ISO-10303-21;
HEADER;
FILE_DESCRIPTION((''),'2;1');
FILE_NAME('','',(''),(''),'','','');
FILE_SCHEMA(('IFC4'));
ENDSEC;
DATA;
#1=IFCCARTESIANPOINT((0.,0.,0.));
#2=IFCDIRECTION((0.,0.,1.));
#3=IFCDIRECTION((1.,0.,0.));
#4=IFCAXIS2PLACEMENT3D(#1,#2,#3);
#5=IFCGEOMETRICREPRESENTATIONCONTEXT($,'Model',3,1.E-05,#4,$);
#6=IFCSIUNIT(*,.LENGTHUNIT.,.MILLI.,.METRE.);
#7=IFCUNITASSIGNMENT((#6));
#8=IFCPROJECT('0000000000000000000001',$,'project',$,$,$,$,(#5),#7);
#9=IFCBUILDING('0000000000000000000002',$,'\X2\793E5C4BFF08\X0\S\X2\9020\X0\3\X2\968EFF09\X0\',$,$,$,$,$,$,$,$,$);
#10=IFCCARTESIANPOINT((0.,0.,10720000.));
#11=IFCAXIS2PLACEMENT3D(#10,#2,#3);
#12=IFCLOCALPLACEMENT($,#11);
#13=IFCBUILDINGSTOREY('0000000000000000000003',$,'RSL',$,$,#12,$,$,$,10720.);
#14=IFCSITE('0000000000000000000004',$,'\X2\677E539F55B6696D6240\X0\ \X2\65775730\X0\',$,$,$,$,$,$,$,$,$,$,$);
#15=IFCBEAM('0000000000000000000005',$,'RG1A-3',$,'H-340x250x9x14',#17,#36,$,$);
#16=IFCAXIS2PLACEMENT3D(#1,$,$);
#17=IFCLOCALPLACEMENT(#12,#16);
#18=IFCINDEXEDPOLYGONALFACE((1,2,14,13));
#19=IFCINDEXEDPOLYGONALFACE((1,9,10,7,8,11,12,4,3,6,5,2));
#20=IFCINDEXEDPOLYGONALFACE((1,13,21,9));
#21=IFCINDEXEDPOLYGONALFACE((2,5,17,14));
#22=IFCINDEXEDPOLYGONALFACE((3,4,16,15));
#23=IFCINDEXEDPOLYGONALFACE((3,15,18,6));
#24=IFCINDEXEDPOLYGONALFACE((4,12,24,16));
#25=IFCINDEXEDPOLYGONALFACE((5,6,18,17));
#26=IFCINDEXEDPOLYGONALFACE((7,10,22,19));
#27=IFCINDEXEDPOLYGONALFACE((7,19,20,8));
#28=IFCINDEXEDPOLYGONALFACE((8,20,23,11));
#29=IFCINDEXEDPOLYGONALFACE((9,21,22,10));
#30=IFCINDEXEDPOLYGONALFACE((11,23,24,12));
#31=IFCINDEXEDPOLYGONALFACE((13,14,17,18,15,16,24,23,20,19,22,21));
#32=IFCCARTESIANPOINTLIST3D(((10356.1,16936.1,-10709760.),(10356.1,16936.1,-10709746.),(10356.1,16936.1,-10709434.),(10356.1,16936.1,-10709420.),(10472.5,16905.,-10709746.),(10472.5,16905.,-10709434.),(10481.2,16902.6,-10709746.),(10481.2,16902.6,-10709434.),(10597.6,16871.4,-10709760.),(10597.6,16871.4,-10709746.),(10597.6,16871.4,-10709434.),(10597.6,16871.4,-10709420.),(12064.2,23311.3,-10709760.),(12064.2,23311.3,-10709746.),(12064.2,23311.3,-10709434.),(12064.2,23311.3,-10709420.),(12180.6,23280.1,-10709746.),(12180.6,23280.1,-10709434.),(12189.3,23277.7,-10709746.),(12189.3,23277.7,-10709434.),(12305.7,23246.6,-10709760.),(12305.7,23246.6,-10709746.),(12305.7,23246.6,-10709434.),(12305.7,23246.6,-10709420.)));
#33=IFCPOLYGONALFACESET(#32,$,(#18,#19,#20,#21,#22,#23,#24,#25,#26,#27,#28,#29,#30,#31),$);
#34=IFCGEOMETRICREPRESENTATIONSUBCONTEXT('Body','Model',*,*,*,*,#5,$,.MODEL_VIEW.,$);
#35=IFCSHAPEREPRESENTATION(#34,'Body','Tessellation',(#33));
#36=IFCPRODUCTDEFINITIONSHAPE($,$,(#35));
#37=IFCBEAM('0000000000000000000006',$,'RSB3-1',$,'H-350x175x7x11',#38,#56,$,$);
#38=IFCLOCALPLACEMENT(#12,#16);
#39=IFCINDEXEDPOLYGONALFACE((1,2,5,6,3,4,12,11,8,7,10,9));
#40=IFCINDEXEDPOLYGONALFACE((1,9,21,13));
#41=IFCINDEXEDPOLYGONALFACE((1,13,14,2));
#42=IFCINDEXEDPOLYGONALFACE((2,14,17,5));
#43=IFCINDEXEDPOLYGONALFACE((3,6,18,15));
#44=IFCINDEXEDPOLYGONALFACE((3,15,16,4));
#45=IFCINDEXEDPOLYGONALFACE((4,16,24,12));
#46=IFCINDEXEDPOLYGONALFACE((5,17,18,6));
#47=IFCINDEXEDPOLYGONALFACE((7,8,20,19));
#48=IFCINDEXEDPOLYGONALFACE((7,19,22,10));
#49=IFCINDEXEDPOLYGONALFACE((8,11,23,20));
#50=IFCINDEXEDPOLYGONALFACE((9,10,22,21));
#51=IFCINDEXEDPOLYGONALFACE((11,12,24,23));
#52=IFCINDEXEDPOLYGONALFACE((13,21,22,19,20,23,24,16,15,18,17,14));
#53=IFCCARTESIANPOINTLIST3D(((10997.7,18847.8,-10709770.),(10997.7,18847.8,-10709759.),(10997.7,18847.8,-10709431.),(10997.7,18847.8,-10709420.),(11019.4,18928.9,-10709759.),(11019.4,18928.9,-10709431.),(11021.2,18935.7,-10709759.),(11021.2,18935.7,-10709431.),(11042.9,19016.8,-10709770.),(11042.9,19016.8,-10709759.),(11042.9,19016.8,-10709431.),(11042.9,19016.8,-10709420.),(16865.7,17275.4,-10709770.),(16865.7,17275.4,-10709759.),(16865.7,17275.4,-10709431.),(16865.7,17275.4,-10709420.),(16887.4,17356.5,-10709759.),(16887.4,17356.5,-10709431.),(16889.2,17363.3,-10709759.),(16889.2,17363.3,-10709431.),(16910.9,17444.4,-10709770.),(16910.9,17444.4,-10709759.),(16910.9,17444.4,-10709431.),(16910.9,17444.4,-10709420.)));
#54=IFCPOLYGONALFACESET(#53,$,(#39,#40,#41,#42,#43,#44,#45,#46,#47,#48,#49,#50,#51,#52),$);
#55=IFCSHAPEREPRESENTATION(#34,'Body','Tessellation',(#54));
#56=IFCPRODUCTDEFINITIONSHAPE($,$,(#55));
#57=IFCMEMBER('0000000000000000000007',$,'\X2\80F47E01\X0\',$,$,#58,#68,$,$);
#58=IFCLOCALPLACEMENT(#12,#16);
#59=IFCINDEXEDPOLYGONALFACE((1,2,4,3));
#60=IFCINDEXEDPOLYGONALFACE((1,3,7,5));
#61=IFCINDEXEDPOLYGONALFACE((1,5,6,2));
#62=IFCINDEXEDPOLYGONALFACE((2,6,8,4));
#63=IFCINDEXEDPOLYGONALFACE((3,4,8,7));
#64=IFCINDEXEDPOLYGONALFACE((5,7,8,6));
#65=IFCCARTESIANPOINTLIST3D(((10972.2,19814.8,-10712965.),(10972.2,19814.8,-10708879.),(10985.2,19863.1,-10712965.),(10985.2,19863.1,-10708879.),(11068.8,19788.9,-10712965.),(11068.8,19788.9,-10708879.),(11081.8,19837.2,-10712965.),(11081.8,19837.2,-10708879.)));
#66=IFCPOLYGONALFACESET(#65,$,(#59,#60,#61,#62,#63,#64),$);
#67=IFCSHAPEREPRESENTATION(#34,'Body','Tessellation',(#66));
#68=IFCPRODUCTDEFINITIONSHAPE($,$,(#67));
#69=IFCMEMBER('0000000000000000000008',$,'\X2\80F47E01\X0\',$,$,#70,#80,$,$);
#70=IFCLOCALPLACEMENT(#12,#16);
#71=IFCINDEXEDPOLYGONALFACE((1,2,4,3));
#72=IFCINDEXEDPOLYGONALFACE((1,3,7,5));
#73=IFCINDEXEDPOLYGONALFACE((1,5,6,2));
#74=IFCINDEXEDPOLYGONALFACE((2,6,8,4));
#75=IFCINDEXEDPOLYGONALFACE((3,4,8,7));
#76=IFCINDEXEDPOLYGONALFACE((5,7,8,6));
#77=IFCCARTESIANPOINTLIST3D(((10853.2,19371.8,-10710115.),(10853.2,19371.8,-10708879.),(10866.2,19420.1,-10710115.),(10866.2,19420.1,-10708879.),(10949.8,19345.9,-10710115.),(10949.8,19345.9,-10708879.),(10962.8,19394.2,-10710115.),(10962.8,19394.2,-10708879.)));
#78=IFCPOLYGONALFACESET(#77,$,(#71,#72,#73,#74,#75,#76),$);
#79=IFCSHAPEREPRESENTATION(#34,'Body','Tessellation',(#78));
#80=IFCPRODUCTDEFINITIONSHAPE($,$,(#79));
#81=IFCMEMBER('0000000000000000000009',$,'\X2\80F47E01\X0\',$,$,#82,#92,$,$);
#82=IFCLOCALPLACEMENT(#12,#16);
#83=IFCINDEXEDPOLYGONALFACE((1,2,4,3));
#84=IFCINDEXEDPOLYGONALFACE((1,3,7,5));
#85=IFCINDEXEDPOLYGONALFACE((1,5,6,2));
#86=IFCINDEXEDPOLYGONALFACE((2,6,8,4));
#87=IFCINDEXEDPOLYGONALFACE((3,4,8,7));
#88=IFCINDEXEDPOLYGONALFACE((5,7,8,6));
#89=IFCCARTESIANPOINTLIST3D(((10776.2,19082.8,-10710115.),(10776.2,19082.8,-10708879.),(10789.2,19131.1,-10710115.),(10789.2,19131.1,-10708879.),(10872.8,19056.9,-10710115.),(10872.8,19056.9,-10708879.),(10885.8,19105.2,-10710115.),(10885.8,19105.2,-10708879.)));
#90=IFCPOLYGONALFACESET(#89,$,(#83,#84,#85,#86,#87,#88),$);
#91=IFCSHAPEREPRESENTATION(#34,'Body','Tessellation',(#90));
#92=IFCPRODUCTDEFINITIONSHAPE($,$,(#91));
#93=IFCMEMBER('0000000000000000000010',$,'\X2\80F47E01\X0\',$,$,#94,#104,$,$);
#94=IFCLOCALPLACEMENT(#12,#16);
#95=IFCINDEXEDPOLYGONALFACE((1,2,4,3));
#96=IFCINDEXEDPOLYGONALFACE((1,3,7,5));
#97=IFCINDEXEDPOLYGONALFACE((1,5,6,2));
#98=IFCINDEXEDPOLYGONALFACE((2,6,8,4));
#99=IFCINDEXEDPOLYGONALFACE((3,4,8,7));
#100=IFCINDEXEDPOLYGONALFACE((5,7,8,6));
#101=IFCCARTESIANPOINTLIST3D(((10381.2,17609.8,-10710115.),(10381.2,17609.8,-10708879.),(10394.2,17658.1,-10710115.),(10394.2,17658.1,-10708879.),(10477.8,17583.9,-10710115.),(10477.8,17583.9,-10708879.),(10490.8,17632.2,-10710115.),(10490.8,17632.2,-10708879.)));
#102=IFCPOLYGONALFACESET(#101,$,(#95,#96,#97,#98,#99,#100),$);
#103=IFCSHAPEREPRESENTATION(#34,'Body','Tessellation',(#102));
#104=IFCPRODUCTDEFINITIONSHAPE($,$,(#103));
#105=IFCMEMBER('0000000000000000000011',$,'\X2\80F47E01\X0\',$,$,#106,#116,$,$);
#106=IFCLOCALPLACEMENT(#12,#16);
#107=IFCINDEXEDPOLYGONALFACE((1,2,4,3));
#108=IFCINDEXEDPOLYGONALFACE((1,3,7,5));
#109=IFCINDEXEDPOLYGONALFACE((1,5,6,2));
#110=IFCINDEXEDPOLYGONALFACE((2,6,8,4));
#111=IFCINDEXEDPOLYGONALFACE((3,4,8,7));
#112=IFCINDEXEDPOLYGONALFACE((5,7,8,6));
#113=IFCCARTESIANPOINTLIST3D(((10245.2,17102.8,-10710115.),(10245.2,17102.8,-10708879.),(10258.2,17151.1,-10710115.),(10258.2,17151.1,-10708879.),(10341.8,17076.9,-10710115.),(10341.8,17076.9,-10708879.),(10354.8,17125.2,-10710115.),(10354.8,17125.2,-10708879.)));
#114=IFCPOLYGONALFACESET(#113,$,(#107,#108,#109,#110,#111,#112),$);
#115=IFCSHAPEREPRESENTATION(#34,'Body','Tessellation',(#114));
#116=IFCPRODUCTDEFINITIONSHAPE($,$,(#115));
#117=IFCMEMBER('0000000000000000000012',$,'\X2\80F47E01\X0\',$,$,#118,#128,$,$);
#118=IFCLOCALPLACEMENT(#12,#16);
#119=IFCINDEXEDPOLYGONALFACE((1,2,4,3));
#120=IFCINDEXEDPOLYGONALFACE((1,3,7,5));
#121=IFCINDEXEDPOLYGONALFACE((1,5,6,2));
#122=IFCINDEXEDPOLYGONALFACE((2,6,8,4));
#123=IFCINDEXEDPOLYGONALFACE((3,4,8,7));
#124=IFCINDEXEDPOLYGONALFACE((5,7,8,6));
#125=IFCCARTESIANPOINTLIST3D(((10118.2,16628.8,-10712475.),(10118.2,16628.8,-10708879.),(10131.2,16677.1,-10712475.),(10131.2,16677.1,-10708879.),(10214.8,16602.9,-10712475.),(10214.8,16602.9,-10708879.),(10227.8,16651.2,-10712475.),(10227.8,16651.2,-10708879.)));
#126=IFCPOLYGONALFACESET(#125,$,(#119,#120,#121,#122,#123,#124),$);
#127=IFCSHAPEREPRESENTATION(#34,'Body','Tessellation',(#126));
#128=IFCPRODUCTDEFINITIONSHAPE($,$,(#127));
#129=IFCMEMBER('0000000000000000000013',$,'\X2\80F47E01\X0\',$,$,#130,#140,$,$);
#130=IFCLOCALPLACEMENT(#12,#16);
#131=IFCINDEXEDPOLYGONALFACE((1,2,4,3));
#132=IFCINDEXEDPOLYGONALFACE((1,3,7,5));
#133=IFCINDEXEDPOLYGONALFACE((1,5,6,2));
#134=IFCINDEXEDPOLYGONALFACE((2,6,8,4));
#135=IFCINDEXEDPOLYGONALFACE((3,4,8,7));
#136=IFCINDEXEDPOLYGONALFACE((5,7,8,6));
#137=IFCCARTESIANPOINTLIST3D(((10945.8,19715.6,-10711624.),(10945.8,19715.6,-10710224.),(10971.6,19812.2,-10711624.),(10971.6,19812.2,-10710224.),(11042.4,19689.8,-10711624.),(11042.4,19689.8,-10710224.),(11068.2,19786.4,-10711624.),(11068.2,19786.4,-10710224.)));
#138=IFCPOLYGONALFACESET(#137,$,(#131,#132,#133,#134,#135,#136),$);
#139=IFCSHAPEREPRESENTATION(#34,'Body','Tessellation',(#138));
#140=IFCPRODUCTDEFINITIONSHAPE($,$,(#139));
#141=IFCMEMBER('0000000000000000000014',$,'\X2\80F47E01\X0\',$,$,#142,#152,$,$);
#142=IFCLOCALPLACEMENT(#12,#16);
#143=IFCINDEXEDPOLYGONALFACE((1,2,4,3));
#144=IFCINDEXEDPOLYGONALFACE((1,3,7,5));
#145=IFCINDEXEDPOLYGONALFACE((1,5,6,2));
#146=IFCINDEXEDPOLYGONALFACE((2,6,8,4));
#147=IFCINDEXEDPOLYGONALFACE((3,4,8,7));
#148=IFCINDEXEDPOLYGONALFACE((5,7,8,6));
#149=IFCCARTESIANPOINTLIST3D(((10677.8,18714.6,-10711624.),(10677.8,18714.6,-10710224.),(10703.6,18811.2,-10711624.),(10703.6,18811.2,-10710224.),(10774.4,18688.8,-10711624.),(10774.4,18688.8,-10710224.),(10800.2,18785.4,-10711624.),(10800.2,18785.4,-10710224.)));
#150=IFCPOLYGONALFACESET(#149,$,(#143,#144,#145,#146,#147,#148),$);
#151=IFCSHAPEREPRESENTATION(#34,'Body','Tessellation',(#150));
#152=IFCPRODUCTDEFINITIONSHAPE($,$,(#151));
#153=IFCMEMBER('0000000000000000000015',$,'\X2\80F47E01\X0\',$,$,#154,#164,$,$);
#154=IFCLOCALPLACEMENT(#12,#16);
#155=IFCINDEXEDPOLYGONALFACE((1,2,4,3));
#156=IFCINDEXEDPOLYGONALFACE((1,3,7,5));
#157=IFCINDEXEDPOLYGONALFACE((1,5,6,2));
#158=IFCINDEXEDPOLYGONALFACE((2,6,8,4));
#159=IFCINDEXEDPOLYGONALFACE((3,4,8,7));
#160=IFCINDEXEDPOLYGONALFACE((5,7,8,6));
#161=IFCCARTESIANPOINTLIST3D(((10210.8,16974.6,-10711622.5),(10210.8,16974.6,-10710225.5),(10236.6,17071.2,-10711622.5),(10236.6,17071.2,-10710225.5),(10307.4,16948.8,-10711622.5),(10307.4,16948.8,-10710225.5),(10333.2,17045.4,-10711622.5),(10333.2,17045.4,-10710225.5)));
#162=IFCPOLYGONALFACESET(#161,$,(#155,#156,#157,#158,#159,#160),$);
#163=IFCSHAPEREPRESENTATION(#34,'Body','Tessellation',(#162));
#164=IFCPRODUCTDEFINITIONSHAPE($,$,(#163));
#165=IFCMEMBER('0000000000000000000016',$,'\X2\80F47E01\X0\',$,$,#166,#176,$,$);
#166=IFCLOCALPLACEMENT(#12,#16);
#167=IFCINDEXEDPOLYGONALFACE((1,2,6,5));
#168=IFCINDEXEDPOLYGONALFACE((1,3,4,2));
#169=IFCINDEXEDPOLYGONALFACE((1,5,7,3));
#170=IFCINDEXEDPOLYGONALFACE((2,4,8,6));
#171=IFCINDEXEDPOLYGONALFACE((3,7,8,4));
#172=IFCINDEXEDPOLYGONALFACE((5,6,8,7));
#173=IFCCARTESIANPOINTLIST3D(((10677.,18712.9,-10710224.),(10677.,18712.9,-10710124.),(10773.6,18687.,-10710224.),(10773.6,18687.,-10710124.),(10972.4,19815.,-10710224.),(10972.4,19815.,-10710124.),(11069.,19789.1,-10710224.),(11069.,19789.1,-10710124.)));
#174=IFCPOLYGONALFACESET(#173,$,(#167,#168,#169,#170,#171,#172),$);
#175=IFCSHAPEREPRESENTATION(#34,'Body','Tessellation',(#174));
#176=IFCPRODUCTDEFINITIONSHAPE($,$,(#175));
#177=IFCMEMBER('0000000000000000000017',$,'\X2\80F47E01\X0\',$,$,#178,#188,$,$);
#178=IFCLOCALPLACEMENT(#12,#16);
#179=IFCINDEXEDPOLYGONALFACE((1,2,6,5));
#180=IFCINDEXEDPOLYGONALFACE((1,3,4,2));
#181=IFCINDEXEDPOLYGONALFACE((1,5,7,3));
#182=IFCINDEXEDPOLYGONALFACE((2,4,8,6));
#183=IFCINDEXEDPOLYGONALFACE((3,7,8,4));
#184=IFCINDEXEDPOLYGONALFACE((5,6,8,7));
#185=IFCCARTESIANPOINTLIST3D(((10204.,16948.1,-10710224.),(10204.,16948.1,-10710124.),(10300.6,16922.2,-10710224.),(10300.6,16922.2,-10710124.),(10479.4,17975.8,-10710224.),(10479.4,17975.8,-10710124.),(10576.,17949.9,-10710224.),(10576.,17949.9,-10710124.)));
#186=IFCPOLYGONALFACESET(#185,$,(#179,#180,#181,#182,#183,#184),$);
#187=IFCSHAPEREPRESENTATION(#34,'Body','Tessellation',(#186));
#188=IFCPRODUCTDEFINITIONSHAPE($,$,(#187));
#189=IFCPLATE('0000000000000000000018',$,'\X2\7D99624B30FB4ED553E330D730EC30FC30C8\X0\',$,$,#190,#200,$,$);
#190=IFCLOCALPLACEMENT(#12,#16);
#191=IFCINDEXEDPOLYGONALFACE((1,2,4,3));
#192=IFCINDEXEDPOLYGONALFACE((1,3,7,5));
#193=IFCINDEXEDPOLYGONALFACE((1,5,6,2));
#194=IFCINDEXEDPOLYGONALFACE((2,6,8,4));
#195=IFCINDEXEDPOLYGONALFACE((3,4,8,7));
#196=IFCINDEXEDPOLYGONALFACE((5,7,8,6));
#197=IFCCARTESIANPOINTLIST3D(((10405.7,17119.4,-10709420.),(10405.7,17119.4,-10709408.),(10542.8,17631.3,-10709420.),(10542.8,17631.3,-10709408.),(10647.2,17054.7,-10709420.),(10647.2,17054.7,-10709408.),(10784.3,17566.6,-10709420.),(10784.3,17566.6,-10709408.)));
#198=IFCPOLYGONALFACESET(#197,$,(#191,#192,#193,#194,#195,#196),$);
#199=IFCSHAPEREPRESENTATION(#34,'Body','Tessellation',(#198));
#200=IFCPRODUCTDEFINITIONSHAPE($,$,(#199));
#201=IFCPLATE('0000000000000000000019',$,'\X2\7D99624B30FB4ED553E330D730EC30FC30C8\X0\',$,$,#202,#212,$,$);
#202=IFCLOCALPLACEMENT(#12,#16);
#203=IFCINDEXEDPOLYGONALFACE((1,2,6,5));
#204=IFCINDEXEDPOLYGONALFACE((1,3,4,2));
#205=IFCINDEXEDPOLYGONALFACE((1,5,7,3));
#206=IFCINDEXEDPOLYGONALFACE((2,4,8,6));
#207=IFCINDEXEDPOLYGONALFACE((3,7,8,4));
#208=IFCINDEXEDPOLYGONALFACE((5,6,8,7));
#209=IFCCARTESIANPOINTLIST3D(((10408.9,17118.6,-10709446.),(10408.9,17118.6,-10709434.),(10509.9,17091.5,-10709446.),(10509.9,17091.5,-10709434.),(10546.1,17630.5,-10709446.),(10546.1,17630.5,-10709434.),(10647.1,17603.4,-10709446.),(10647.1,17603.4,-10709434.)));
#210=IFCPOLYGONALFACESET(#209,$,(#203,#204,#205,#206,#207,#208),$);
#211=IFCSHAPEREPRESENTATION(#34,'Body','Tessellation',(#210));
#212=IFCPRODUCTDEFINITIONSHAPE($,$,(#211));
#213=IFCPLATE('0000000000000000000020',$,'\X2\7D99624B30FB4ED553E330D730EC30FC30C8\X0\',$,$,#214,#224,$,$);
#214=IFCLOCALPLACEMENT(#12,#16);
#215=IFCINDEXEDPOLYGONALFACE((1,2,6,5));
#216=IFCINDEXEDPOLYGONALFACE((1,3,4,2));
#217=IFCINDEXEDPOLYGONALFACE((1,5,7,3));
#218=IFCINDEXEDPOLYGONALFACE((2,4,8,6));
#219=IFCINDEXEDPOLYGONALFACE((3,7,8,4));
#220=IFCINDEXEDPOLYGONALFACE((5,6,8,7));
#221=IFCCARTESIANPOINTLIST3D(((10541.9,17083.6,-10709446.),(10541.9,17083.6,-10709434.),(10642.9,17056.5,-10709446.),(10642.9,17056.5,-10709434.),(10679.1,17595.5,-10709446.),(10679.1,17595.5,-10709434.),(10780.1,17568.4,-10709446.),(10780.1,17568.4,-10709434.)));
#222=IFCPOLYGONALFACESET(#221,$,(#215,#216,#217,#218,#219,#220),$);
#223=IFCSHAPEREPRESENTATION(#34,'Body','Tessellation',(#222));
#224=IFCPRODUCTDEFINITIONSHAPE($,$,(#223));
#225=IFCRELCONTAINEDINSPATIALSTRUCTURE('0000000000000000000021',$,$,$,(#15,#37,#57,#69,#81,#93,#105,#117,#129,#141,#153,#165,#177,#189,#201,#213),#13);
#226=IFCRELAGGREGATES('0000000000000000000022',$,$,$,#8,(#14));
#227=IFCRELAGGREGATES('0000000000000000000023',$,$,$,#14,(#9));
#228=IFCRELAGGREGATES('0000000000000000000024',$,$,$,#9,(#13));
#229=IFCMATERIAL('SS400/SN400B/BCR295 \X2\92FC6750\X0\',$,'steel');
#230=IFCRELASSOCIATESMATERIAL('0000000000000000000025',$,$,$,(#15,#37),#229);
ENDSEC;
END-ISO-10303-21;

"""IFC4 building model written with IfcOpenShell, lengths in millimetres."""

from ifc_helpers import new_model, si_unit, frame, origin, origin_with_axes, place, context, subcontext, project, spatial, rectangle, i_section, extrude, material, element, save


model = new_model("IFC4")

# Units and contexts
model_context = context("Model", 3, precision=1e-05, world=origin_with_axes())
body_context = subcontext(model_context, "Body", "Model", "MODEL_VIEW")
ifc_project = project(units=[si_unit("LENGTHUNIT", "METRE", prefix="MILLI")], contexts=[model_context])

# Site, building, storey
site = spatial("IfcSite", under=ifc_project, Name="松原営業所 敷地")
building = spatial("IfcBuilding", under=site, Name="社屋（S造3階）")
storey_placement = place(None, frame((0.0, 0.0, 10720000.0), z_axis=(0.0, 0.0, 1.0), x_axis=(1.0, 0.0, 0.0)))
storey = spatial("IfcBuildingStorey", under=building, at=storey_placement, Name="RSL", Elevation=10720.0)

# Beams
ifc_material = material(Name="SS400/SN400B/BCR295 鋼材", Category="steel")
beam_1_placement = place(storey_placement, frame((10476.8, 16903.8, -10709420.0), z_axis=(0.258812, 0.965928, 0.0), x_axis=(-0.965928, 0.258812, 0.0)))
element("IfcBeam", 1, at=beam_1_placement, inside=storey, material=ifc_material, Name="RG1A-3", ObjectType="H-340x250x9x14", context=body_context, shape_type="SweptSolid", body=[
    extrude(i_section(OverallWidth=250.0, OverallDepth=340.0, WebThickness=9.0, FlangeThickness=14.0), frame((0.0, -170.0, 0.0)), (0.0, 0.0, 1.0), 6600.0),
])
beam_2_placement = place(storey_placement, frame((11020.3, 18932.3, -10709420.0), z_axis=(0.965923, -0.25883, 0.0), x_axis=(0.25883, 0.965923, 0.0)))
element("IfcBeam", 2, at=beam_2_placement, inside=storey, material=ifc_material, Name="RSB3-1", ObjectType="H-350x175x7x11", context=body_context, shape_type="SweptSolid", body=[
    extrude(i_section(OverallWidth=175.0, OverallDepth=350.0, WebThickness=7.0, FlangeThickness=11.0), frame((0.0, -175.0, 0.0)), (0.0, 0.0, 1.0), 6075.0),
])

# Members
member_1_placement = place(storey_placement, frame((11033.5, 19850.1, -10710922.0), z_axis=(-0.258819, -0.965926, 0.0), x_axis=(0.965926, -0.258819, 0.0)))
element("IfcMember", 3, at=member_1_placement, inside=storey, Name="胴縁", context=body_context, shape_type="SweptSolid", body=[
    extrude(rectangle(XDim=100.0, YDim=4086.0), origin(), (0.0, 0.0, 1.0), 50.0),
])
for number, where, z_axis, x_axis, name in (
    (4, (10914.5, 19407.1, -10709497.0), (-0.258819, -0.965926, 0.0), (0.965926, -0.258819, 0.0), "胴縁"),
    (5, (10837.5, 19118.1, -10709497.0), (-0.258819, -0.965926, 0.0), (0.965926, -0.258819, 0.0), "胴縁"),
    (6, (10442.5, 17645.1, -10709497.0), (-0.258819, -0.965926, 0.0), (0.965926, -0.258819, 0.0), "胴縁"),
    (7, (10306.5, 17138.1, -10709497.0), (-0.258819, -0.965926, 0.0), (0.965926, -0.258819, 0.0), "胴縁"),
):
    element("IfcMember", number, at=place(storey_placement, frame(where, z_axis=z_axis, x_axis=x_axis)), inside=storey, Name=name, context=body_context, shape_type="SweptSolid", body=[
        extrude(rectangle(XDim=100.0, YDim=1236.0), origin(), (0.0, 0.0, 1.0), 50.0),
    ])
member_2_placement = place(storey_placement, frame((10179.5, 16664.1, -10710677.0), z_axis=(-0.258819, -0.965926, 0.0), x_axis=(0.965926, -0.258819, 0.0)))
element("IfcMember", 8, at=member_2_placement, inside=storey, Name="胴縁", context=body_context, shape_type="SweptSolid", body=[
    extrude(rectangle(XDim=100.0, YDim=3596.0), origin(), (0.0, 0.0, 1.0), 50.0),
])
for number, where, z_axis, x_axis, name in (
    (9, (11019.9, 19799.3, -10710924.0), (-0.258819, -0.965926, 0.0), (0.965926, -0.258819, 0.0), "胴縁"),
    (10, (10751.9, 18798.3, -10710924.0), (-0.258819, -0.965926, 0.0), (0.965926, -0.258819, 0.0), "胴縁"),
):
    element("IfcMember", number, at=place(storey_placement, frame(where, z_axis=z_axis, x_axis=x_axis)), inside=storey, Name=name, context=body_context, shape_type="SweptSolid", body=[
        extrude(rectangle(XDim=100.0, YDim=1400.0), origin(), (0.0, 0.0, 1.0), 100.0),
    ])
member_3_placement = place(storey_placement, frame((10284.9, 17058.3, -10710924.0), z_axis=(-0.258819, -0.965926, 0.0), x_axis=(0.965926, -0.258819, 0.0)))
element("IfcMember", 11, at=member_3_placement, inside=storey, Name="胴縁", context=body_context, shape_type="SweptSolid", body=[
    extrude(rectangle(XDim=100.0, YDim=1397.0), origin(), (0.0, 0.0, 1.0), 100.0),
])
member_4_placement = place(storey_placement, frame((11020.7, 19802.1, -10710174.0), z_axis=(-0.258819, -0.965926, 0.0), x_axis=(0.965926, -0.258819, 0.0)))
element("IfcMember", 12, at=member_4_placement, inside=storey, Name="胴縁", context=body_context, shape_type="SweptSolid", body=[
    extrude(rectangle(XDim=100.0, YDim=100.0), origin(), (0.0, 0.0, 1.0), 1141.0),
])
member_5_placement = place(storey_placement, frame((10527.7, 17962.9, -10710174.0), z_axis=(-0.258819, -0.965926, 0.0), x_axis=(0.965926, -0.258819, 0.0)))
element("IfcMember", 13, at=member_5_placement, inside=storey, Name="胴縁", context=body_context, shape_type="SweptSolid", body=[
    extrude(rectangle(XDim=100.0, YDim=100.0), origin(), (0.0, 0.0, 1.0), 1064.0),
])

# Plates
plate_1_placement = place(storey_placement, frame((10526.4, 17087.0, -10709414.0), z_axis=(0.258819, 0.965926, 0.0), x_axis=(-0.965926, 0.258819, 0.0)))
element("IfcPlate", 14, at=plate_1_placement, inside=storey, Name="継手・仕口プレート", context=body_context, shape_type="SweptSolid", body=[
    extrude(rectangle(XDim=250.0, YDim=12.0), origin(), (0.0, 0.0, 1.0), 530.0),
])
for number, where, z_axis, x_axis, name in (
    (15, (10459.4, 17105.0, -10709440.0), (0.258819, 0.965926, 0.0), (-0.965926, 0.258819, 0.0), "継手・仕口プレート"),
    (16, (10592.4, 17070.0, -10709440.0), (0.258819, 0.965926, 0.0), (-0.965926, 0.258819, 0.0), "継手・仕口プレート"),
):
    element("IfcPlate", number, at=place(storey_placement, frame(where, z_axis=z_axis, x_axis=x_axis)), inside=storey, Name=name, context=body_context, shape_type="SweptSolid", body=[
        extrude(rectangle(XDim=104.5, YDim=12.0), origin(), (0.0, 0.0, 1.0), 530.0),
    ])

save(model, "model.ifc")
